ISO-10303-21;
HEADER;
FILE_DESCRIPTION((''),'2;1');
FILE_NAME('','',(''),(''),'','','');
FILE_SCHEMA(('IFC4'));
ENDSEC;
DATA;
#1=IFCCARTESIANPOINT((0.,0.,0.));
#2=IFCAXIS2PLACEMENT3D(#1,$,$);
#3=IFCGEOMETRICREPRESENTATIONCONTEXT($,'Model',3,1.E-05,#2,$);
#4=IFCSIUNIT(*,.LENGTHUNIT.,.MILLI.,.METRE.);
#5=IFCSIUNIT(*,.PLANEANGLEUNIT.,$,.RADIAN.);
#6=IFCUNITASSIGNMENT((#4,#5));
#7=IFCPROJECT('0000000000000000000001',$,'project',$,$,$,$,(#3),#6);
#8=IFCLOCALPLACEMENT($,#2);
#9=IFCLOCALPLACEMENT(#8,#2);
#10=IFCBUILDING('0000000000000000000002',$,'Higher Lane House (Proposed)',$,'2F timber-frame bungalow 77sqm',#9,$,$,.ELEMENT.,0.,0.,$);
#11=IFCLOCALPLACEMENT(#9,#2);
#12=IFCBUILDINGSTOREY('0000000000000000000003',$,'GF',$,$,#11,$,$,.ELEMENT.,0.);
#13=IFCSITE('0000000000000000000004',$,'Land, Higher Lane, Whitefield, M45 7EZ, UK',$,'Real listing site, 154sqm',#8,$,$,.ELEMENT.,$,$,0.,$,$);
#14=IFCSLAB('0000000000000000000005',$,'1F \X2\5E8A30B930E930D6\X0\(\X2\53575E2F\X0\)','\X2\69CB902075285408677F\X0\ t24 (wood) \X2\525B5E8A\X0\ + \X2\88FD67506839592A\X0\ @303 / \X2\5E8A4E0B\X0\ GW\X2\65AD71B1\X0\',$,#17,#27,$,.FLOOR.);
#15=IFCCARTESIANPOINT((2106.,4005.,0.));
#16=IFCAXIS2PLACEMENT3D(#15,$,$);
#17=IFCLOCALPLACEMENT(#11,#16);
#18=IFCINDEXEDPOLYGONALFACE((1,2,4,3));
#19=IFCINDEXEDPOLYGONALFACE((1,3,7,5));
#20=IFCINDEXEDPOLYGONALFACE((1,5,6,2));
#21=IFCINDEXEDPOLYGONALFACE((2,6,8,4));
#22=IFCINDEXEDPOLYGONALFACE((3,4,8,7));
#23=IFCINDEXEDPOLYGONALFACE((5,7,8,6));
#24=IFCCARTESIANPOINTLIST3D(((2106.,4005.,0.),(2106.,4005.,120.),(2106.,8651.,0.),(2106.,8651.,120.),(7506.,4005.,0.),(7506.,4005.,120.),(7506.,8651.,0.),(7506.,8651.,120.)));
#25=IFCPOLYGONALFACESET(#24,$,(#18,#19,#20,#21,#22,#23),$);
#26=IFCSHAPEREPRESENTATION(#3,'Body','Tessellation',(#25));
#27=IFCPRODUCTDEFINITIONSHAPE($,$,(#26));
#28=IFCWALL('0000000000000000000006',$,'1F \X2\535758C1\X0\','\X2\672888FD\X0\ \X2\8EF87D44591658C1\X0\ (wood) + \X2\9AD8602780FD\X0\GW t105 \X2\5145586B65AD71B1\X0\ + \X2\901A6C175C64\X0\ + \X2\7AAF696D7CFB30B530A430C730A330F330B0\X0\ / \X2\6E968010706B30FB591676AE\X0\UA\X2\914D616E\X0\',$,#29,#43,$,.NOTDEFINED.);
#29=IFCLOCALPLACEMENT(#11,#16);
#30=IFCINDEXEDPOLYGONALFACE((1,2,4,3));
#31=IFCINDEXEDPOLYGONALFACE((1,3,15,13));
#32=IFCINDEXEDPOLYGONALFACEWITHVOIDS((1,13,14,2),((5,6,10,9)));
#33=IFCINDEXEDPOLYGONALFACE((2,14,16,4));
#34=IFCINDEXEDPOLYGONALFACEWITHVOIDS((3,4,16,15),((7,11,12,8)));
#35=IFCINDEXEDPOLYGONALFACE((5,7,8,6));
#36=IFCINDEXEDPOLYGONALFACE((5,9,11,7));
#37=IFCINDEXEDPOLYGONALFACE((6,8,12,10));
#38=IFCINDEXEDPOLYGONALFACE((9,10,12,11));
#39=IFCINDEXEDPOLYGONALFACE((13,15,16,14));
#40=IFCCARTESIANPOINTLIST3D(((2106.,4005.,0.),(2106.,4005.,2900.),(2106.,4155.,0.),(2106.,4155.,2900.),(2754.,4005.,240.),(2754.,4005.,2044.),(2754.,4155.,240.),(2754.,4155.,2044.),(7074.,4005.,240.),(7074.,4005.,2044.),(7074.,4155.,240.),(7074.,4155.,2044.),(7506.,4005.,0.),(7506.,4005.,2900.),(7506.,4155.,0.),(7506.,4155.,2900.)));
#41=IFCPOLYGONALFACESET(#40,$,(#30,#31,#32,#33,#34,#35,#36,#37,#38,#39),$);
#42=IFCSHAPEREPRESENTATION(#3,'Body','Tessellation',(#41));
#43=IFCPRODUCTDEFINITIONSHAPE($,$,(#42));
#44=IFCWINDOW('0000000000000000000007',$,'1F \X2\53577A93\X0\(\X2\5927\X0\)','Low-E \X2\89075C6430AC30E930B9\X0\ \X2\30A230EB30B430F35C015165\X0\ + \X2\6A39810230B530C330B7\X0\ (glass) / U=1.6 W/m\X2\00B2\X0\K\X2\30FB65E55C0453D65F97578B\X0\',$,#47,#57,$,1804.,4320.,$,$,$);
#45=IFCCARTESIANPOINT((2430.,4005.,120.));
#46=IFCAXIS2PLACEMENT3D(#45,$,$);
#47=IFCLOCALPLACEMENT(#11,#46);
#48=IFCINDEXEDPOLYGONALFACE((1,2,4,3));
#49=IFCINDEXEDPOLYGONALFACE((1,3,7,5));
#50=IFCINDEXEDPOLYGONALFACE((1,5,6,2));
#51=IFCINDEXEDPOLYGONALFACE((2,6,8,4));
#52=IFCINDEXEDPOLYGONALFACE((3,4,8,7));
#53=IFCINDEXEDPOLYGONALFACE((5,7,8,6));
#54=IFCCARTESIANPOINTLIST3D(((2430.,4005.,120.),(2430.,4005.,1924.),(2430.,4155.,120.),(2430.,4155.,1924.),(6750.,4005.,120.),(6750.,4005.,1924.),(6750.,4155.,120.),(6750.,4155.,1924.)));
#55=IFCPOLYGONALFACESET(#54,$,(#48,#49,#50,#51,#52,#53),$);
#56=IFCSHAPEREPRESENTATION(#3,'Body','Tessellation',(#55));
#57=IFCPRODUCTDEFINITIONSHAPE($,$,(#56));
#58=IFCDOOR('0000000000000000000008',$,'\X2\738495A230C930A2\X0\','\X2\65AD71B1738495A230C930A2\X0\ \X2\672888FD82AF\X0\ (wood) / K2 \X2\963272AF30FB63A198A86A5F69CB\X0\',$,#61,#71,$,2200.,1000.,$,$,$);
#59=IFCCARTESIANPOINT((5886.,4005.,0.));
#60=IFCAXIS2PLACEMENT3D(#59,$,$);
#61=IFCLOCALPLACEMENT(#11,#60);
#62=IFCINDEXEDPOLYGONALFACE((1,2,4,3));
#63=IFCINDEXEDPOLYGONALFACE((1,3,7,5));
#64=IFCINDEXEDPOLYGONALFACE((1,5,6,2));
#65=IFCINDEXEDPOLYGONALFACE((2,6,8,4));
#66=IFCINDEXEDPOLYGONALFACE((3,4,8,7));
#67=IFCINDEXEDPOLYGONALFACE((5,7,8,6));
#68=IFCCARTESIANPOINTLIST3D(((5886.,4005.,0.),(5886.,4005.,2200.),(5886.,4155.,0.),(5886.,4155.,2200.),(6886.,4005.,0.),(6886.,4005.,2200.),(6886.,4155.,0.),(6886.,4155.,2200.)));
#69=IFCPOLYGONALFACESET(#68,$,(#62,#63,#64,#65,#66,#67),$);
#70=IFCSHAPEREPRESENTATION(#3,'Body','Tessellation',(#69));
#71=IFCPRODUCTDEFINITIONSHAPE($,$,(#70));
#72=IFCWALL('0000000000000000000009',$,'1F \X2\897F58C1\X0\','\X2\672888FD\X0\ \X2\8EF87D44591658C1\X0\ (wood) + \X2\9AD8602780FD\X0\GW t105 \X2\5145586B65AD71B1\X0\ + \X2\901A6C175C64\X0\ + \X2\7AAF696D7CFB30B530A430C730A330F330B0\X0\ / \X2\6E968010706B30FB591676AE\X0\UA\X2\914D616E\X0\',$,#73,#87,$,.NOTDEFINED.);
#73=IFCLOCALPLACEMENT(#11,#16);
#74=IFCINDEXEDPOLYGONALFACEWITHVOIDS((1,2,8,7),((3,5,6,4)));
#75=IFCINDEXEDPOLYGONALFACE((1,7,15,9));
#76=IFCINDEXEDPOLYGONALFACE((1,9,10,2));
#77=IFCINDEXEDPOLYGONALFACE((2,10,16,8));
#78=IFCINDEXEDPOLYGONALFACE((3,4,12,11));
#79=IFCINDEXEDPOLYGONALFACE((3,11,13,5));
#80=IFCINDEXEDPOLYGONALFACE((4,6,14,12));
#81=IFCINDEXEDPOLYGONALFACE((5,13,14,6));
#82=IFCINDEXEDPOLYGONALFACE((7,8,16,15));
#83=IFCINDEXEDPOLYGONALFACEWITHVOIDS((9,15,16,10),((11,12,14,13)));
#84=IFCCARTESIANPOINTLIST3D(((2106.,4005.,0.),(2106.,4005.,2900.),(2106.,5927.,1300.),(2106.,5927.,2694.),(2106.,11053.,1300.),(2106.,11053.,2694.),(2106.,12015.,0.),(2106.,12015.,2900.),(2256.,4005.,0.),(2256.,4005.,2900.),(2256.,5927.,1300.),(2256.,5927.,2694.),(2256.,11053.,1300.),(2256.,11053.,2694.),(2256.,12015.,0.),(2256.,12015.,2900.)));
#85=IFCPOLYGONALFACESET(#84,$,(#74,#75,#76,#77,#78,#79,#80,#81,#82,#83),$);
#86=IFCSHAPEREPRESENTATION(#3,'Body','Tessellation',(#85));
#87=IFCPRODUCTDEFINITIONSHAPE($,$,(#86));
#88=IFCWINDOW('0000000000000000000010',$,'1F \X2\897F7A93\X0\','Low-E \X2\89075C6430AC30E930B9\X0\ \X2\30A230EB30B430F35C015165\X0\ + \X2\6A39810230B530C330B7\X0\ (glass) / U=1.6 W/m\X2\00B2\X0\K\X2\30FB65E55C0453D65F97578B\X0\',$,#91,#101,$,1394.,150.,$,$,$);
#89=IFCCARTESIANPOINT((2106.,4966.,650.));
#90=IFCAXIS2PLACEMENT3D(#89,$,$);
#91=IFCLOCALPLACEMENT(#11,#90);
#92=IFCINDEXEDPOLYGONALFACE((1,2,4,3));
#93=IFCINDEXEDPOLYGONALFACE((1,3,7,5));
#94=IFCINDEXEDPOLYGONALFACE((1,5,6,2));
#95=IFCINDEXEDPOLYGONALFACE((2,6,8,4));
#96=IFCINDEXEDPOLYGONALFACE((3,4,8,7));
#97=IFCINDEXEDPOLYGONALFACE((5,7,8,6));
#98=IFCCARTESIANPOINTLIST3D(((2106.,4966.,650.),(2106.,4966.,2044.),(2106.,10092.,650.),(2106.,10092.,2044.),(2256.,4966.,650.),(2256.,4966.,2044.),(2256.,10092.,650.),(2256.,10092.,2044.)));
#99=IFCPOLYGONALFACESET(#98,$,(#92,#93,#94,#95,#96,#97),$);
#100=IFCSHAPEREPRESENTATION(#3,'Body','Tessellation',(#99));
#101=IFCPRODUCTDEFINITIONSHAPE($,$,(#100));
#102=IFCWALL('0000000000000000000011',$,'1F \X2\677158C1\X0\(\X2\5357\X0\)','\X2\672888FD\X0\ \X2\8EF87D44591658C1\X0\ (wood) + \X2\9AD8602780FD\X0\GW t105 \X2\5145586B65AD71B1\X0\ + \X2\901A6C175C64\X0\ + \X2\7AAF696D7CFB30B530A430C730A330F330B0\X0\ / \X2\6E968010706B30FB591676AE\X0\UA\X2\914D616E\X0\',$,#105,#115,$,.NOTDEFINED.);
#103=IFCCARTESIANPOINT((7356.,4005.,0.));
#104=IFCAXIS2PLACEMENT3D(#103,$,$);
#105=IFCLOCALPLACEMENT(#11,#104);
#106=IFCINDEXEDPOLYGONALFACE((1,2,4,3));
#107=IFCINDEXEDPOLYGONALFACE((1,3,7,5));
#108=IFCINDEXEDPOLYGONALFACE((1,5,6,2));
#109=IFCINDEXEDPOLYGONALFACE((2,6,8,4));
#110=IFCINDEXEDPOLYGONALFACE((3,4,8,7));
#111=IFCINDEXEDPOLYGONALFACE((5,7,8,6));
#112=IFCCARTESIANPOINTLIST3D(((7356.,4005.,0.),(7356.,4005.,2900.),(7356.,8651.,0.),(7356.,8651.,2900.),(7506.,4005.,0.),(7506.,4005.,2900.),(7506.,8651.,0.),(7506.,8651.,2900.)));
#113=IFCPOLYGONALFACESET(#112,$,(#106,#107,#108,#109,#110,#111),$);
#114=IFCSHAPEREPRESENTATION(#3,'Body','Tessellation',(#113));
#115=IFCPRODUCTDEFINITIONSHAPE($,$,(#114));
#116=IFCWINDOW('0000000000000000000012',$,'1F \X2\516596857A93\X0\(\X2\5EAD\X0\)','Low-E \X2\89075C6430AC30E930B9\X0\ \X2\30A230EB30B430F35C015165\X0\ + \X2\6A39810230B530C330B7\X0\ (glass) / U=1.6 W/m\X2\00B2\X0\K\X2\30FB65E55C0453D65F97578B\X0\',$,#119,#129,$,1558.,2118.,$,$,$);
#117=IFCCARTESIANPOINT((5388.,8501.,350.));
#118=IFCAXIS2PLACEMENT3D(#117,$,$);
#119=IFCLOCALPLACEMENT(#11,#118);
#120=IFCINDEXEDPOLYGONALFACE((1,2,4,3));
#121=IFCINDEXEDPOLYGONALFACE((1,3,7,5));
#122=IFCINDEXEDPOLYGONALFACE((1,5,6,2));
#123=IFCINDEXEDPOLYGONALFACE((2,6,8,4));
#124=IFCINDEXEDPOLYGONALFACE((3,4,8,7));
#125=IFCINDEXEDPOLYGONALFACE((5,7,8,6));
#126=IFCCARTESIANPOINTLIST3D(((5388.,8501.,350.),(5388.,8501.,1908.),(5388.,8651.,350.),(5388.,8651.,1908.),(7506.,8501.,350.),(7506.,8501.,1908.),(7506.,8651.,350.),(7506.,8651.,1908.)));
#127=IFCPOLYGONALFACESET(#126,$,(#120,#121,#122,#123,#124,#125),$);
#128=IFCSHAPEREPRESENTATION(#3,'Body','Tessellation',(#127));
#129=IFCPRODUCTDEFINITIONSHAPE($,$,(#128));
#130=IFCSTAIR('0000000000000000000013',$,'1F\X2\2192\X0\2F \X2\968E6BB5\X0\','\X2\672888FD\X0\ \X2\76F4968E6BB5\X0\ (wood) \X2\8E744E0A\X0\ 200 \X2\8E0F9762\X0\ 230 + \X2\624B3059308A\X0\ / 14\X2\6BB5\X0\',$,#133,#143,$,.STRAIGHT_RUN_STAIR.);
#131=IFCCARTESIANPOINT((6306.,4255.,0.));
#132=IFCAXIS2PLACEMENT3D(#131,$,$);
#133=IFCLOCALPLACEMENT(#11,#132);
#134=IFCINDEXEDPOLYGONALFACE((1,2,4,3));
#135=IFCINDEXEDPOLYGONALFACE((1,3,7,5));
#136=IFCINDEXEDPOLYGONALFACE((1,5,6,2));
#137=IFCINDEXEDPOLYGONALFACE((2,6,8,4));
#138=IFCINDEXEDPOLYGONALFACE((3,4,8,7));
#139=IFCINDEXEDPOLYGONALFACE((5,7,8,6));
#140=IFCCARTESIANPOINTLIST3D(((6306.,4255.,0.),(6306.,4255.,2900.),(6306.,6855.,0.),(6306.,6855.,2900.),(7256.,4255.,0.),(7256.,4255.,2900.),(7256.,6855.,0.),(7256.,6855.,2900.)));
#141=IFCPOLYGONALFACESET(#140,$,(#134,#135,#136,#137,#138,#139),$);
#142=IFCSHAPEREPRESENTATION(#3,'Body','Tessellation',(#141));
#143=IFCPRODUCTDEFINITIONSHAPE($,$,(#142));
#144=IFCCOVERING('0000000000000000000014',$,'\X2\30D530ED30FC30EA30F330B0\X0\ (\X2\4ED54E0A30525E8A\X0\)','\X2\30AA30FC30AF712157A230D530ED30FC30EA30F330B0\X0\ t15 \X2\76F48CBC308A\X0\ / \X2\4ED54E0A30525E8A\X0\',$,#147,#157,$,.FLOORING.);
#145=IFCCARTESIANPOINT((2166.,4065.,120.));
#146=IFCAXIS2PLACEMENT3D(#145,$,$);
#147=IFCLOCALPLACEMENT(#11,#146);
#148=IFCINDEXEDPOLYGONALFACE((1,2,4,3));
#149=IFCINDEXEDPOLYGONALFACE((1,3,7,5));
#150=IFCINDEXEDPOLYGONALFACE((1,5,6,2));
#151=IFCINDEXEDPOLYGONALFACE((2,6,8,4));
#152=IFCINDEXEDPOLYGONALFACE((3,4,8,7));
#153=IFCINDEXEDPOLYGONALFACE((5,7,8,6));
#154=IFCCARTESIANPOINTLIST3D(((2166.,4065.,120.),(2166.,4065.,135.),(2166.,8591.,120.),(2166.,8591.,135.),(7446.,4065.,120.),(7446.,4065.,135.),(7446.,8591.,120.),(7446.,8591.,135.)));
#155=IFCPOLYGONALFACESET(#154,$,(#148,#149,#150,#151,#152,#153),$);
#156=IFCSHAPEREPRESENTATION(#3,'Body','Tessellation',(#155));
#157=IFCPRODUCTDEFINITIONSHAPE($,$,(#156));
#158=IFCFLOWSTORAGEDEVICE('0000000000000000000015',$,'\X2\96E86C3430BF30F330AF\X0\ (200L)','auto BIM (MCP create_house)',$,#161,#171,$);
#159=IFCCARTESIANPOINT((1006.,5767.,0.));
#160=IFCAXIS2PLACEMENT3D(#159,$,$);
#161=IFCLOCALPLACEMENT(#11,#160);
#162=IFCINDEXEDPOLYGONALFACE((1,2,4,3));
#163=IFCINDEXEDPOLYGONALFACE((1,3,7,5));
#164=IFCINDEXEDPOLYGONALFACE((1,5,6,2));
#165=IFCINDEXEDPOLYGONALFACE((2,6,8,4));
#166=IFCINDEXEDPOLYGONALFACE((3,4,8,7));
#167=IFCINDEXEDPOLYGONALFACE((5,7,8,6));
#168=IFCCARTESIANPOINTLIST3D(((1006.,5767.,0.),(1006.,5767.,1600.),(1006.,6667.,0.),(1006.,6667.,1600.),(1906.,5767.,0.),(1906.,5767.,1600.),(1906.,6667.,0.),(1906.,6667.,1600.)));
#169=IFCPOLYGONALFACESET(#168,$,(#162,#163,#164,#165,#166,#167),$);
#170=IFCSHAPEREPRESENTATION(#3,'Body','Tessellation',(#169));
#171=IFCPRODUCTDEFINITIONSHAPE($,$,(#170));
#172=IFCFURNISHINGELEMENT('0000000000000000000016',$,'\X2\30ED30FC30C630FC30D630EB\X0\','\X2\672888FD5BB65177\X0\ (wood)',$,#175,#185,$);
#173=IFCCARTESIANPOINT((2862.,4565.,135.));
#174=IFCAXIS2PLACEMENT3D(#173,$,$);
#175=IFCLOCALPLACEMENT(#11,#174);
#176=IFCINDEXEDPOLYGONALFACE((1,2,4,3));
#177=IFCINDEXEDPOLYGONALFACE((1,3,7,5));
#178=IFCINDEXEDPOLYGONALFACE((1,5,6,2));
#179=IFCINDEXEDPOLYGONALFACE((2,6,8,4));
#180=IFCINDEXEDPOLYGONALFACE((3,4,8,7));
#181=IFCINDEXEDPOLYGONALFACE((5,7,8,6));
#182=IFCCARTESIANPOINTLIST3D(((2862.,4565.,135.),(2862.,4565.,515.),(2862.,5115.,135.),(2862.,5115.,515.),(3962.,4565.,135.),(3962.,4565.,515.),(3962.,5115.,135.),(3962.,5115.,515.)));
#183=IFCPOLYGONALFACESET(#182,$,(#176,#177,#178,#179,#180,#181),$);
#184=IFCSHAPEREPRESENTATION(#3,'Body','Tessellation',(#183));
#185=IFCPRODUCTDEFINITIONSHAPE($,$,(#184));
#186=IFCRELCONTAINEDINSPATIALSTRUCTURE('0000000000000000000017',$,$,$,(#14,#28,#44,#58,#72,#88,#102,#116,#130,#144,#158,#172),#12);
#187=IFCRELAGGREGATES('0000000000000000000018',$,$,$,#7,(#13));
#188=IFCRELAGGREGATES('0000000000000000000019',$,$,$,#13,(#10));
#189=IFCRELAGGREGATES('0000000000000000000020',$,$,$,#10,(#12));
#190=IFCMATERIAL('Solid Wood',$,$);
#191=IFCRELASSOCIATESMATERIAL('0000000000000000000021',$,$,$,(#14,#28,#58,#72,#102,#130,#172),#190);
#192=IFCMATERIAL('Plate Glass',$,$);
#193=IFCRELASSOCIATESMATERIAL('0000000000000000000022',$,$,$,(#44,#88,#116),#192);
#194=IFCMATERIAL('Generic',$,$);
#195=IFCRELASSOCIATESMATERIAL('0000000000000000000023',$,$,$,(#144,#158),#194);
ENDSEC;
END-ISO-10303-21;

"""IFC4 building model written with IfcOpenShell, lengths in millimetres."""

from ifc_helpers import new_model, si_unit, frame, frame_2d, origin, place, context, project, spatial, rectangle, extrude, material, element, fill, save


model = new_model("IFC4")

# Units and contexts
model_context = context("Model", 3, precision=1e-05, world=origin())
ifc_project = project(units=[si_unit("LENGTHUNIT", "METRE", prefix="MILLI"), si_unit("PLANEANGLEUNIT", "RADIAN")], contexts=[model_context])

# Site, building, storey
site_placement = place(None, origin())
site = spatial("IfcSite", under=ifc_project, at=site_placement, Name="Land, Higher Lane, Whitefield, M45 7EZ, UK", ObjectType="Real listing site, 154sqm", CompositionType="ELEMENT", RefElevation=0.0)
building_placement = place(site_placement, origin())
building = spatial("IfcBuilding", under=site, at=building_placement, Name="Higher Lane House (Proposed)", ObjectType="2F timber-frame bungalow 77sqm", CompositionType="ELEMENT", ElevationOfRefHeight=0.0, ElevationOfTerrain=0.0)
storey_placement = place(building_placement, origin())
storey = spatial("IfcBuildingStorey", under=building, at=storey_placement, Name="GF", CompositionType="ELEMENT", Elevation=0.0)

# Slab
ifc_material_1 = material(Name="Solid Wood")
slab_1_placement = place(storey_placement, frame((2106.0, 4005.0, 0.0)))
element("IfcSlab", 1, at=slab_1_placement, inside=storey, material=ifc_material_1, Name="1F 床スラブ(南帯)", Description="構造用合板 t24 (wood) 剛床 + 製材根太 @303 / 床下 GW断熱", PredefinedType="FLOOR", context=model_context, shape_type="SweptSolid", body=[
    extrude(rectangle(XDim=5400.0, YDim=4646.0, at=frame_2d((2700.0, 2323.0))), frame((2106.0, 4005.0, 0.0)), (0.0, 0.0, 1.0), 120.0),
])

# Wall, openings, window, door
wall_1_placement = place(storey_placement, frame((2106.0, 4005.0, 0.0)))
wall_1 = element("IfcWall", 2, at=wall_1_placement, inside=storey, material=ifc_material_1, Name="1F 南壁", Description="木製 軸組外壁 (wood) + 高性能GW t105 充填断熱 + 通気層 + 窯業系サイディング / 準耐火・外皮UA配慮", PredefinedType="NOTDEFINED", context=model_context, shape_type="SweptSolid", body=[
    extrude(rectangle(XDim=5400.0, YDim=150.0, at=frame_2d((2700.0, 75.0))), frame((2106.0, 4005.0, 0.0)), (0.0, 0.0, 1.0), 2900.0),
])
opening_1_placement = place(storey_placement, frame((2430.0, 4005.0, 120.0)))
opening_1 = element("IfcOpeningElement", 3, at=opening_1_placement, cuts=wall_1, PredefinedType="NOTDEFINED", context=model_context, shape_type="SweptSolid", body=[
    extrude(rectangle(XDim=4320.0, YDim=150.0, at=frame_2d((2160.0, 75.0))), frame((2430.0, 4005.0, 120.0)), (0.0, 0.0, 1.0), 1804.0),
])
opening_2_placement = place(storey_placement, frame((5886.0, 4005.0, 0.0)))
opening_2 = element("IfcOpeningElement", 4, at=opening_2_placement, cuts=wall_1, PredefinedType="NOTDEFINED", context=model_context, shape_type="SweptSolid", body=[
    extrude(rectangle(XDim=1000.0, YDim=150.0, at=frame_2d((500.0, 75.0))), frame((5886.0, 4005.0, 0.0)), (0.0, 0.0, 1.0), 2200.0),
])
ifc_material_2 = material(Name="Plate Glass")
window_1_placement = place(storey_placement, frame((2430.0, 4005.0, 120.0)))
window_1 = element("IfcWindow", 5, at=window_1_placement, inside=storey, material=ifc_material_2, Name="1F 南窓(大)", Description="Low-E 複層ガラス アルゴン封入 + 樹脂サッシ (glass) / U=1.6 W/m²K・日射取得型", OverallHeight=1804.0, OverallWidth=4320.0, context=model_context, shape_type="SweptSolid", body=[
    extrude(rectangle(XDim=4320.0, YDim=150.0, at=frame_2d((2160.0, 75.0))), frame((2430.0, 4005.0, 120.0)), (0.0, 0.0, 1.0), 1804.0),
])
fill(opening_1, window_1)
door_1_placement = place(storey_placement, frame((5886.0, 4005.0, 0.0)))
door_1 = element("IfcDoor", 6, at=door_1_placement, inside=storey, material=ifc_material_1, Name="玄関ドア", Description="断熱玄関ドア 木製芯 (wood) / K2 防犯・採風機構", OverallHeight=2200.0, OverallWidth=1000.0, context=model_context, shape_type="SweptSolid", body=[
    extrude(rectangle(XDim=1000.0, YDim=150.0, at=frame_2d((500.0, 75.0))), frame((5886.0, 4005.0, 0.0)), (0.0, 0.0, 1.0), 2200.0),
])
fill(opening_2, door_1)

# Walls, openings, windows
wall_2_placement = place(storey_placement, frame((2106.0, 4005.0, 0.0)))
wall_2 = element("IfcWall", 7, at=wall_2_placement, inside=storey, material=ifc_material_1, Name="1F 西壁", Description="木製 軸組外壁 (wood) + 高性能GW t105 充填断熱 + 通気層 + 窯業系サイディング / 準耐火・外皮UA配慮", PredefinedType="NOTDEFINED", context=model_context, shape_type="SweptSolid", body=[
    extrude(rectangle(XDim=150.0, YDim=8010.0, at=frame_2d((75.0, 4005.0))), frame((2106.0, 4005.0, 0.0)), (0.0, 0.0, 1.0), 2900.0),
])
opening_3_placement = place(storey_placement, frame((2106.0, 4966.0, 650.0)))
opening_3 = element("IfcOpeningElement", 8, at=opening_3_placement, cuts=wall_2, PredefinedType="NOTDEFINED", context=model_context, shape_type="SweptSolid", body=[
    extrude(rectangle(XDim=150.0, YDim=5126.0, at=frame_2d((75.0, 2563.0))), frame((2106.0, 4966.0, 650.0)), (0.0, 0.0, 1.0), 1394.0),
])
window_2_placement = place(storey_placement, frame((2106.0, 4966.0, 650.0)))
window_2 = element("IfcWindow", 9, at=window_2_placement, inside=storey, material=ifc_material_2, Name="1F 西窓", Description="Low-E 複層ガラス アルゴン封入 + 樹脂サッシ (glass) / U=1.6 W/m²K・日射取得型", OverallHeight=1394.0, OverallWidth=150.0, context=model_context, shape_type="SweptSolid", body=[
    extrude(rectangle(XDim=150.0, YDim=5126.0, at=frame_2d((75.0, 2563.0))), frame((2106.0, 4966.0, 650.0)), (0.0, 0.0, 1.0), 1394.0),
])
fill(opening_3, window_2)
wall_3_placement = place(storey_placement, frame((7356.0, 4005.0, 0.0)))
wall_3 = element("IfcWall", 10, at=wall_3_placement, inside=storey, material=ifc_material_1, Name="1F 東壁(南)", Description="木製 軸組外壁 (wood) + 高性能GW t105 充填断熱 + 通気層 + 窯業系サイディング / 準耐火・外皮UA配慮", PredefinedType="NOTDEFINED", context=model_context, shape_type="SweptSolid", body=[
    extrude(rectangle(XDim=150.0, YDim=4646.0, at=frame_2d((75.0, 2323.0))), frame((7356.0, 4005.0, 0.0)), (0.0, 0.0, 1.0), 2900.0),
])
opening_4_placement = place(storey_placement, frame((5388.0, 8501.0, 350.0)))
opening_4 = element("IfcOpeningElement", 11, at=opening_4_placement, cuts=wall_3, PredefinedType="NOTDEFINED", context=model_context, shape_type="SweptSolid", body=[
    extrude(rectangle(XDim=2118.0, YDim=150.0, at=frame_2d((1059.0, 75.0))), frame((5388.0, 8501.0, 350.0)), (0.0, 0.0, 1.0), 1558.0),
])
window_3_placement = place(storey_placement, frame((5388.0, 8501.0, 350.0)))
window_3 = element("IfcWindow", 12, at=window_3_placement, inside=storey, material=ifc_material_2, Name="1F 入隅窓(庭)", Description="Low-E 複層ガラス アルゴン封入 + 樹脂サッシ (glass) / U=1.6 W/m²K・日射取得型", OverallHeight=1558.0, OverallWidth=2118.0, context=model_context, shape_type="SweptSolid", body=[
    extrude(rectangle(XDim=2118.0, YDim=150.0, at=frame_2d((1059.0, 75.0))), frame((5388.0, 8501.0, 350.0)), (0.0, 0.0, 1.0), 1558.0),
])
fill(opening_4, window_3)

# Stair
stair_placement = place(storey_placement, frame((6306.0, 4255.0, 0.0)))
element("IfcStair", 13, at=stair_placement, inside=storey, material=ifc_material_1, Name="1F→2F 階段", Description="木製 直階段 (wood) 蹴上 200 踏面 230 + 手すり / 14段", PredefinedType="STRAIGHT_RUN_STAIR", context=model_context, shape_type="SweptSolid", body=[
    extrude(rectangle(XDim=950.0, YDim=2600.0, at=frame_2d((475.0, 1300.0))), frame((6306.0, 4255.0, 0.0)), (0.0, 0.0, 1.0), 2900.0),
])

# Covering
ifc_material_3 = material(Name="Generic")
covering_placement = place(storey_placement, frame((2166.0, 4065.0, 120.0)))
element("IfcCovering", 14, at=covering_placement, inside=storey, material=ifc_material_3, Name="フローリング (仕上げ床)", Description="オーク無垢フローリング t15 直貼り / 仕上げ床", PredefinedType="FLOORING", context=model_context, shape_type="SweptSolid", body=[
    extrude(rectangle(XDim=5280.0, YDim=4526.0, at=frame_2d((2640.0, 2263.0))), frame((2166.0, 4065.0, 120.0)), (0.0, 0.0, 1.0), 15.0),
])

# Flow storage device
flow_storage_device_placement = place(storey_placement, frame((1006.0, 5767.0, 0.0)))
element("IfcFlowStorageDevice", 15, at=flow_storage_device_placement, inside=storey, material=ifc_material_3, Name="雨水タンク (200L)", Description="auto BIM (MCP create_house)", context=model_context, shape_type="SweptSolid", body=[
    extrude(rectangle(XDim=900.0, YDim=900.0, at=frame_2d((450.0, 450.0))), frame((1006.0, 5767.0, 0.0)), (0.0, 0.0, 1.0), 1600.0),
])

# Furnishing element
furnishing_1_placement = place(storey_placement, frame((2862.0, 4565.0, 135.0)))
element("IfcFurnishingElement", 16, at=furnishing_1_placement, inside=storey, material=ifc_material_1, Name="ローテーブル", Description="木製家具 (wood)", context=model_context, shape_type="SweptSolid", body=[
    extrude(rectangle(XDim=1100.0, YDim=550.0, at=frame_2d((550.0, 275.0))), frame((2862.0, 4565.0, 135.0)), (0.0, 0.0, 1.0), 380.0),
])

save(model, "model.ifc")
